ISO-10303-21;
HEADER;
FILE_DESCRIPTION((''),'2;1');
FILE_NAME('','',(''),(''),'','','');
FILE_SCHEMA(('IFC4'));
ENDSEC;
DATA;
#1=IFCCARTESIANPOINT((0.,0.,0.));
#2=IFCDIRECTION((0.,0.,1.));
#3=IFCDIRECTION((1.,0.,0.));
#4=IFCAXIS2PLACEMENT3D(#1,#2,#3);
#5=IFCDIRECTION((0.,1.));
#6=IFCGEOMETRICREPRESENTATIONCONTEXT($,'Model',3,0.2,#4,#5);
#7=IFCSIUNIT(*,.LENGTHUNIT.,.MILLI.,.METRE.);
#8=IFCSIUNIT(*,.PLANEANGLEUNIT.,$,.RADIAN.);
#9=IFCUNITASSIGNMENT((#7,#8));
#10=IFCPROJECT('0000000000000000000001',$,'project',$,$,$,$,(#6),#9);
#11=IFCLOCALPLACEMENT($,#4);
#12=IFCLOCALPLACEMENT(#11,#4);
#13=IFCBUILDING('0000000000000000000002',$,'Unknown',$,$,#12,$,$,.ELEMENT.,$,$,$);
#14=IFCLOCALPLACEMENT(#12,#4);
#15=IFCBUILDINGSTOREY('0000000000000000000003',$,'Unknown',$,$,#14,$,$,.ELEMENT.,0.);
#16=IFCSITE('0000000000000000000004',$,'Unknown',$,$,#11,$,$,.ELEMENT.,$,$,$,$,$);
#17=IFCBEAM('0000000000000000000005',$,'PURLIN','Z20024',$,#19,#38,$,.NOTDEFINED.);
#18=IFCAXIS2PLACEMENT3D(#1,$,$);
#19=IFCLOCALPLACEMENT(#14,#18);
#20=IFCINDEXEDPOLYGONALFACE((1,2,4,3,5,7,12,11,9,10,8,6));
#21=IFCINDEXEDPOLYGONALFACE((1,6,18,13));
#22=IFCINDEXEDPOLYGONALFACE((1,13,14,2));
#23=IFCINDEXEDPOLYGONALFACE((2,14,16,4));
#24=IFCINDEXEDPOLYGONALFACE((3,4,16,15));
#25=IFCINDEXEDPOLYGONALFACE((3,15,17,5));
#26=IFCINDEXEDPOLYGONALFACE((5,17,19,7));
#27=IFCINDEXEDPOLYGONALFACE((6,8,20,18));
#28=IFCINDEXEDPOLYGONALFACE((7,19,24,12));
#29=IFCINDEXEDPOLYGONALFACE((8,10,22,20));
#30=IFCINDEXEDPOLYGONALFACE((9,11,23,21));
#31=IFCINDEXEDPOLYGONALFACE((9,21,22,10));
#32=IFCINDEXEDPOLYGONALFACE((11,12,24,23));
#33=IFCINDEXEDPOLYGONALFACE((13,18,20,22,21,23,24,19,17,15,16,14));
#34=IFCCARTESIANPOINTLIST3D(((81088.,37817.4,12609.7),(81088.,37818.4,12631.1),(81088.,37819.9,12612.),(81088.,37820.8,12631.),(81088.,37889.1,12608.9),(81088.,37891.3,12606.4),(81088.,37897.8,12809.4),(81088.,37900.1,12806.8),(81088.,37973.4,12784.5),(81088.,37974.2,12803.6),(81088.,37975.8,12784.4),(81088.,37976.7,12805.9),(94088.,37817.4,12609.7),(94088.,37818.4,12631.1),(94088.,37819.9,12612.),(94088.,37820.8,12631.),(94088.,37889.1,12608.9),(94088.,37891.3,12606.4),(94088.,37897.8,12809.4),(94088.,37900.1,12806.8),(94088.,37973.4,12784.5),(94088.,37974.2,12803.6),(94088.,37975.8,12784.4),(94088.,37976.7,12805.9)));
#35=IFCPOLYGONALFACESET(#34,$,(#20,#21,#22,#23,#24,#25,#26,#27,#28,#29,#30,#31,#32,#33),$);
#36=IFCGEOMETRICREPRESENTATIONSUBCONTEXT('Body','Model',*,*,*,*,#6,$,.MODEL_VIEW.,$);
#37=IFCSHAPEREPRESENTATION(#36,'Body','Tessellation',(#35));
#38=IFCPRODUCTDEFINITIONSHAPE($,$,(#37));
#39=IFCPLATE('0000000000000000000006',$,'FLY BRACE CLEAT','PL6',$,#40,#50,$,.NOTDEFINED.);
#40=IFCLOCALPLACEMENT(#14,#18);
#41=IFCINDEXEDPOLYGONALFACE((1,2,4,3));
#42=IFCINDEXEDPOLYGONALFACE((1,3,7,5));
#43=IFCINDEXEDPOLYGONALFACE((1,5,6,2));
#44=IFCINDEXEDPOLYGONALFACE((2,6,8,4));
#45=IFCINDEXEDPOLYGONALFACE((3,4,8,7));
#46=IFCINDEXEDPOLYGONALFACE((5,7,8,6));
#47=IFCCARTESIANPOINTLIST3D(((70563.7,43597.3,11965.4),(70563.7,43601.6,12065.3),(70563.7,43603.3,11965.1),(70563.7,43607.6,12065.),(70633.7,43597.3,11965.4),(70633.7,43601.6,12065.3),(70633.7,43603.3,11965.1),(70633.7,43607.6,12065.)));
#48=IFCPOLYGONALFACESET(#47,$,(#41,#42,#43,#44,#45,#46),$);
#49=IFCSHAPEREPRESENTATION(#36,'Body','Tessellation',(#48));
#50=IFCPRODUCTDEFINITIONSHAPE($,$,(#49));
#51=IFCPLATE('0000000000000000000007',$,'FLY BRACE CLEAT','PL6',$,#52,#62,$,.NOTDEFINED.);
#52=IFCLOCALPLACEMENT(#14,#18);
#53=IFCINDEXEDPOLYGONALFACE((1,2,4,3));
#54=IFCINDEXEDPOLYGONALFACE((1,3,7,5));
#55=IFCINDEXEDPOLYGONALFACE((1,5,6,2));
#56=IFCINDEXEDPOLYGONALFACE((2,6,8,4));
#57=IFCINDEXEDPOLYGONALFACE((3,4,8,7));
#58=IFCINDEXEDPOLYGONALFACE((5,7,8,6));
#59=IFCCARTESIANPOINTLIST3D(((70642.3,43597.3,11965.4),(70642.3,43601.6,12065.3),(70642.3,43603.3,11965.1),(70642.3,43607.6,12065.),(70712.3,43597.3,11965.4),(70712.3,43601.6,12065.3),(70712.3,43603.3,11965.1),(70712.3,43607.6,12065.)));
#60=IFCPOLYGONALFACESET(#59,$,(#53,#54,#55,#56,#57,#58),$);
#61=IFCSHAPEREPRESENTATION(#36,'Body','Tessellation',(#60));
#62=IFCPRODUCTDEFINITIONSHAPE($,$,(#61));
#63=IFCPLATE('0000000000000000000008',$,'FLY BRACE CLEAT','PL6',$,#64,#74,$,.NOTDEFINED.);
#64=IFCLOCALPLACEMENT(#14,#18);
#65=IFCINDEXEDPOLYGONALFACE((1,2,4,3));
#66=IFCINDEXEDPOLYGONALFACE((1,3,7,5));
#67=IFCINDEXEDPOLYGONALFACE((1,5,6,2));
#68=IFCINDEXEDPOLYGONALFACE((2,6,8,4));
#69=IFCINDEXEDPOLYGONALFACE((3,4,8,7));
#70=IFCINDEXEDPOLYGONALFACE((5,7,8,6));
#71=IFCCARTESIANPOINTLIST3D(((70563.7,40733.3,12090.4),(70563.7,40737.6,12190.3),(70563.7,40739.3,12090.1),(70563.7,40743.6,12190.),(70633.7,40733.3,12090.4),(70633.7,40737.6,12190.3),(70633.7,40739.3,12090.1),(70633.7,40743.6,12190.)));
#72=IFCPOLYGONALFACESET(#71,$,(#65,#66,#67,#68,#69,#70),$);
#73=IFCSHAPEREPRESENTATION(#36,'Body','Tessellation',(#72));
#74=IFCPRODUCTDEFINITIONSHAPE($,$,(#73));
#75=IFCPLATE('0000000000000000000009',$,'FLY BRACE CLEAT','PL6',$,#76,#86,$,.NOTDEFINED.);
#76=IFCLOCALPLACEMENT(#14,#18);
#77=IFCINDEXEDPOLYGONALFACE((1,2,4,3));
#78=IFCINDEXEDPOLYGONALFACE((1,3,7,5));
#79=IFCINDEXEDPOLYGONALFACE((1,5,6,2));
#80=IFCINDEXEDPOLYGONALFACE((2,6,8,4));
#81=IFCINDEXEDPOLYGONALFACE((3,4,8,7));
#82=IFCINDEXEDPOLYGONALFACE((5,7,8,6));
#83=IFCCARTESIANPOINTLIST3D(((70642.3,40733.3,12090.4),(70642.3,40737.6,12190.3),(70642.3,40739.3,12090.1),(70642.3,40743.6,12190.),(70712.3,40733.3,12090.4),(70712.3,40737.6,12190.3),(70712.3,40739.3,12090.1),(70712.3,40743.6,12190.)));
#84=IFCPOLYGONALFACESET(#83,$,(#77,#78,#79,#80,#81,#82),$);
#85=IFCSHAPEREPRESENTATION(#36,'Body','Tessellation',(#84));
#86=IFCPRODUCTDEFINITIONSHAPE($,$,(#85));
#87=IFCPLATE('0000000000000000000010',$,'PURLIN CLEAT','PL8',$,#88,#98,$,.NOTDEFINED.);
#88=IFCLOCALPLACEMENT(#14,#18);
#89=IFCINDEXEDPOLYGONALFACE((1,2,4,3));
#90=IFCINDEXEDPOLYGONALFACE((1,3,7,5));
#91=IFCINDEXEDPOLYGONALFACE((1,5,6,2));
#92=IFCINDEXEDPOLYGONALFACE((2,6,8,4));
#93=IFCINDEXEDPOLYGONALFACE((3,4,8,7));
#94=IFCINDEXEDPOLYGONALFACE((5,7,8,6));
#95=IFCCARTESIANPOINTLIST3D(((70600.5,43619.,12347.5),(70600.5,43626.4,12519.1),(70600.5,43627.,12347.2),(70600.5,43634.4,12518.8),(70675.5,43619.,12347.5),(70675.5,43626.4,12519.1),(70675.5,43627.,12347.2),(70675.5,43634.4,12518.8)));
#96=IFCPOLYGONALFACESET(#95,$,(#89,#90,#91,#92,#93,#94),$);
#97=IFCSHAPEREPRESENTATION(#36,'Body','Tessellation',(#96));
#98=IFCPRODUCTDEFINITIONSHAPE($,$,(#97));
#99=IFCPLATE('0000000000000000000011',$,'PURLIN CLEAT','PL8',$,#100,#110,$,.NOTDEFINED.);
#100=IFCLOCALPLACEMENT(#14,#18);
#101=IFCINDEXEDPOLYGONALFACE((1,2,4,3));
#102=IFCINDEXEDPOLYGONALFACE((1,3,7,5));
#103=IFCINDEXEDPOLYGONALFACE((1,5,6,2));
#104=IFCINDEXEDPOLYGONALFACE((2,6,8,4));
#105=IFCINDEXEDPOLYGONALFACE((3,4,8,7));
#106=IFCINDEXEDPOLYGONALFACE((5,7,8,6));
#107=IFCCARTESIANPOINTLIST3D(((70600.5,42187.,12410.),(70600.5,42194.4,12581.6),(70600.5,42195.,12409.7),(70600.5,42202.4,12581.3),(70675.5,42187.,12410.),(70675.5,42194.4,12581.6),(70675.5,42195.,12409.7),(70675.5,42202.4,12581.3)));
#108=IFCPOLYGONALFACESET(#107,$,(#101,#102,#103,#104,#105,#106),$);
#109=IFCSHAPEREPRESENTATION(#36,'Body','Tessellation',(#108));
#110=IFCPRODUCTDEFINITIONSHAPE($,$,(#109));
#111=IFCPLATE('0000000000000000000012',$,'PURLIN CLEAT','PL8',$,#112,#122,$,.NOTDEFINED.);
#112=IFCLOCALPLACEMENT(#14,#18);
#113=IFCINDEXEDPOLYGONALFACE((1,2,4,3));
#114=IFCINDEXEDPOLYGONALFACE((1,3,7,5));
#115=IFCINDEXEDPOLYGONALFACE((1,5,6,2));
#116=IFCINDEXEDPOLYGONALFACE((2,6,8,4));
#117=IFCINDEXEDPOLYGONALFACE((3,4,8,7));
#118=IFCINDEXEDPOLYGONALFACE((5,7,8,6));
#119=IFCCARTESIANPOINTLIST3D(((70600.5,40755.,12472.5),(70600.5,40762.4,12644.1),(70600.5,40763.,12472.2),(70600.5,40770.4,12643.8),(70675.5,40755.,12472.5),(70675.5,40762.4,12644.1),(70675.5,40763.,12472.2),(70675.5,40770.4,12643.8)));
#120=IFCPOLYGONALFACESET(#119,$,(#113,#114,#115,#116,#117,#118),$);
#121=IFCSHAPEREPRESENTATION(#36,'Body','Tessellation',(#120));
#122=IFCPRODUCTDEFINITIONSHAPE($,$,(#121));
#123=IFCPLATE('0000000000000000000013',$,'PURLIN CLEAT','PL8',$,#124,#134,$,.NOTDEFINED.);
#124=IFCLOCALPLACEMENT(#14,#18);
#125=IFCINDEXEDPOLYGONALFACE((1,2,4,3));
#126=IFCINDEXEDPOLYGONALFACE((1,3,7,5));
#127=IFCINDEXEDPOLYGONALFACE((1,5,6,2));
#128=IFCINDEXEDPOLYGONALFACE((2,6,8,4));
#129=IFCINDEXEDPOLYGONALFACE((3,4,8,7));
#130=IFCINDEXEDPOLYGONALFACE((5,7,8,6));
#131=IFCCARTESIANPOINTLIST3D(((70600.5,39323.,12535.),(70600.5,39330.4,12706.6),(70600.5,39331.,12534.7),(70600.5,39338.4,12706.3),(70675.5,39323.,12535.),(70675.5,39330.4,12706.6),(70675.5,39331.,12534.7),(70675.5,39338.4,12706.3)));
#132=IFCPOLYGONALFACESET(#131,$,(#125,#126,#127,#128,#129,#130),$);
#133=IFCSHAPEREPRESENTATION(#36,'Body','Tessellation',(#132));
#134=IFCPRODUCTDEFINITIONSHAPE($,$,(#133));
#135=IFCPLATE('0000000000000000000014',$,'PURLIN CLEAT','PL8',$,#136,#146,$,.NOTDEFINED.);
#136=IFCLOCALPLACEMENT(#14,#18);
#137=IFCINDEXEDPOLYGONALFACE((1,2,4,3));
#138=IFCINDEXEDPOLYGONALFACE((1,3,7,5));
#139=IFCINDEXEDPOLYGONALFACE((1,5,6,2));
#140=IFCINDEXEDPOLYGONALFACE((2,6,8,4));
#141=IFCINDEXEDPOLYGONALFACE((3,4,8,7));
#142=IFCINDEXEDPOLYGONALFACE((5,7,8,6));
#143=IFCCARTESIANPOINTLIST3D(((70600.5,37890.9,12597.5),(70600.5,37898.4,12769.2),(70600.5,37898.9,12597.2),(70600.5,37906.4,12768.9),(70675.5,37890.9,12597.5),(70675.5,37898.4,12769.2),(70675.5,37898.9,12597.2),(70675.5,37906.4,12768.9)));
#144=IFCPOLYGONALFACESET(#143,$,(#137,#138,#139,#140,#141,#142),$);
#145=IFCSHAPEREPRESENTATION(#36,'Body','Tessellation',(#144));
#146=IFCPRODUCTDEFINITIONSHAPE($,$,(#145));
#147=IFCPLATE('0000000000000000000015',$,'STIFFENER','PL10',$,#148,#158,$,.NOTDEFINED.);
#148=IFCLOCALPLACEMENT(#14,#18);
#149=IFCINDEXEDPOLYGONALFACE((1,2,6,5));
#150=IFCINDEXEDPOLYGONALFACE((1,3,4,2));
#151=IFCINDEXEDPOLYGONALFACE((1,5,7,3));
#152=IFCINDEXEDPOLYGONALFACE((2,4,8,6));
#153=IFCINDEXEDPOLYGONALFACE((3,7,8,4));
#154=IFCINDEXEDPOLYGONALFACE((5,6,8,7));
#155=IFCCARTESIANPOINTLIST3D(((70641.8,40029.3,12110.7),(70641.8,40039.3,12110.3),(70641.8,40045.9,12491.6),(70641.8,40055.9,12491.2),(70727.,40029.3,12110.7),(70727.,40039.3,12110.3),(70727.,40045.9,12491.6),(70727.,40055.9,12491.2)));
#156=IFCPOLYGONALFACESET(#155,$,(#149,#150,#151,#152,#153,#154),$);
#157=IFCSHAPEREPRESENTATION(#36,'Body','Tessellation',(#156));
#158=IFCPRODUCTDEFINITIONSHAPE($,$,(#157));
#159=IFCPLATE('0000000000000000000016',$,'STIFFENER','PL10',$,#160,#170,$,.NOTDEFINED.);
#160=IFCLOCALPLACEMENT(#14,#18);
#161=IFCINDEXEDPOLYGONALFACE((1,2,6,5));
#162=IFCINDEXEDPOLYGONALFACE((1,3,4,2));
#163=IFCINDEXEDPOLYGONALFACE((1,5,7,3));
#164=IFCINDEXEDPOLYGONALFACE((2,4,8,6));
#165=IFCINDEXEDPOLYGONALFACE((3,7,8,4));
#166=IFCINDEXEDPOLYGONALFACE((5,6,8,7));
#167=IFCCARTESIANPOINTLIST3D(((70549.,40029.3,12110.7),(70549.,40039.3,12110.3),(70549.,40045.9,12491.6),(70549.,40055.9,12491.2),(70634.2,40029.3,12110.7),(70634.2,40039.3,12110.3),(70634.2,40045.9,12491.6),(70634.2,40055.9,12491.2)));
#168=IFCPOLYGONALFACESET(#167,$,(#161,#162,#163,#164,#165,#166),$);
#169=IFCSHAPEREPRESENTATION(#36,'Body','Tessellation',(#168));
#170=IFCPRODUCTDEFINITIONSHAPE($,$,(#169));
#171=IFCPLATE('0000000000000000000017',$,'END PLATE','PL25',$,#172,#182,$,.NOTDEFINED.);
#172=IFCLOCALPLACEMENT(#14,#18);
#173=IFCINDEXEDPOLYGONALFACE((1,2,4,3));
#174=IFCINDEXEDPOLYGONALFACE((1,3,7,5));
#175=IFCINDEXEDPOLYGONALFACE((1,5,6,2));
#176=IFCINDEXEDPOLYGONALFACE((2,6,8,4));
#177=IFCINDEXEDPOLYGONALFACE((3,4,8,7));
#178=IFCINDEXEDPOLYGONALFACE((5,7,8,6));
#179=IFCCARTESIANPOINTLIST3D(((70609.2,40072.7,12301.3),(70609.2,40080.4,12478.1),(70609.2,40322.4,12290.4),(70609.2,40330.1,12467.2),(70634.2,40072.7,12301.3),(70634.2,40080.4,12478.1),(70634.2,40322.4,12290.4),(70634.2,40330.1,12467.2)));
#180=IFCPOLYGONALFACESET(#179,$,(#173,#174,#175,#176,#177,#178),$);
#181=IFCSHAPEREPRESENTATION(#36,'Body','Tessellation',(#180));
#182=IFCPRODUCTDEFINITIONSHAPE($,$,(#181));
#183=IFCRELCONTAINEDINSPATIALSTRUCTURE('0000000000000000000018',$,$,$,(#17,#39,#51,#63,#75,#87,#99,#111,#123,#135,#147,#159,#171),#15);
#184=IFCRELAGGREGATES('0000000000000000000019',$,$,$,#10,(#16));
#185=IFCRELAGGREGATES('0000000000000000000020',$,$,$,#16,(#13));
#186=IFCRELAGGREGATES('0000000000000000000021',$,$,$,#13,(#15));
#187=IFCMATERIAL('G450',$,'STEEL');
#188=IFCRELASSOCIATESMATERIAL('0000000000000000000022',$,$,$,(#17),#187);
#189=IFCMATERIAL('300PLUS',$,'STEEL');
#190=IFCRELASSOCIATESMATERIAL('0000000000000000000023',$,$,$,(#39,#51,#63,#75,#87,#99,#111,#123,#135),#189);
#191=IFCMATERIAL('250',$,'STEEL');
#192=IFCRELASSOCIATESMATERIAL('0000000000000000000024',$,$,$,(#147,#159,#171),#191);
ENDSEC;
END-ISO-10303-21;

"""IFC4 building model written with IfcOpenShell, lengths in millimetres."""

from ifc_helpers import new_model, si_unit, direction, frame, origin_with_axes, place, context, subcontext, project, spatial, line, indexed_curve, outline, extrude, material, element, save


model = new_model("IFC4")

# Units and contexts
model_context = context("Model", 3, precision=0.2, world=origin_with_axes(), true_north=direction((0.0, 1.0)))
body_context = subcontext(model_context, "Body", "Model", "MODEL_VIEW")
ifc_project = project(units=[si_unit("LENGTHUNIT", "METRE", prefix="MILLI"), si_unit("PLANEANGLEUNIT", "RADIAN")], contexts=[model_context])

# Site, building, storey
site_placement = place(None, origin_with_axes())
site = spatial("IfcSite", under=ifc_project, at=site_placement, Name="Unknown", CompositionType="ELEMENT")
building_placement = place(site_placement, origin_with_axes())
building = spatial("IfcBuilding", under=site, at=building_placement, Name="Unknown", CompositionType="ELEMENT")
storey_placement = place(building_placement, origin_with_axes())
storey = spatial("IfcBuildingStorey", under=building, at=storey_placement, Name="Unknown", CompositionType="ELEMENT", Elevation=0.0)

# Shared definitions
ifc_material_1 = material(Name="300PLUS", Category="STEEL")

# Beam
ifc_material_2 = material(Name="G450", Category="STEEL")
for number, where, z_axis, x_axis, name in (
    (1, (81088.0, 37894.6, 12707.9), (0.0, -0.999048, 0.043619), (1.0, 0.0, 0.0), "PURLIN"),
):
    element("IfcBeam", number, at=place(storey_placement, frame(where, z_axis=z_axis, x_axis=x_axis)), inside=storey, material=ifc_material_2, Name=name, Description="Z20024", PredefinedType="NOTDEFINED", context=body_context, shape_type="SolidModel", body=[
        extrude(outline(indexed_curve([(72.8, -101.5), (72.8, -80.0), (70.4, -80.0), (70.4, -99.1), (1.2, -99.1), (1.2, 101.5), (-77.8, 101.5), (-77.8, 80.0), (-75.4, 80.0), (-75.4, 99.1), (-1.2, 99.1), (-1.2, -101.5)], segments=[line(1, 2, 3, 4, 5, 6, 7, 8, 9, 10, 11, 12, 1)])), frame((0.0, 0.0, 0.0), z_axis=(-1.0, 0.0, 0.0), x_axis=(0.0, 0.0, 1.0)), (0.0, 0.0, -1.0), 13000.0),
    ])

# Plates
for number, where, z_axis, x_axis, name in (
    (2, (70633.7, 43604.6, 12065.1), (0.0, -0.999075, 0.043003), (-1.0, 0.0, 0.0), "FLY BRACE CLEAT"),
    (3, (70712.3, 43604.6, 12065.1), (0.0, -0.999075, 0.043003), (-1.0, 0.0, 0.0), "FLY BRACE CLEAT"),
    (4, (70633.7, 40740.6, 12190.1), (0.0, -0.999075, 0.043003), (-1.0, 0.0, 0.0), "FLY BRACE CLEAT"),
    (5, (70712.3, 40740.6, 12190.1), (0.0, -0.999075, 0.043003), (-1.0, 0.0, 0.0), "FLY BRACE CLEAT"),
):
    element("IfcPlate", number, at=place(storey_placement, frame(where, z_axis=z_axis, x_axis=x_axis)), inside=storey, material=ifc_material_1, Name=name, Description="PL6", PredefinedType="NOTDEFINED", context=body_context, shape_type="SolidModel", body=[
        extrude(outline(indexed_curve([(0.0, 0.0), (70.0, 0.0), (70.0, 100.0), (0.0, 100.0)], segments=[line(1, 2, 3, 4, 1)])), frame((0.0, 0.0, 3.0), z_axis=(0.0, 0.0, 1.0), x_axis=(1.0, 0.0, 0.0)), (0.0, 0.0, -1.0), 6.0),
    ])
for number, where, z_axis, x_axis, name in (
    (6, (70600.5, 43623.0, 12347.4), (0.0, -0.999071, 0.043084), (1.0, 0.0, 0.0), "PURLIN CLEAT"),
    (7, (70600.5, 42191.0, 12409.9), (0.0, -0.999071, 0.043084), (1.0, 0.0, 0.0), "PURLIN CLEAT"),
    (8, (70600.5, 40759.0, 12472.4), (0.0, -0.999071, 0.043084), (1.0, 0.0, 0.0), "PURLIN CLEAT"),
    (9, (70600.5, 39327.0, 12534.9), (0.0, -0.999071, 0.043084), (1.0, 0.0, 0.0), "PURLIN CLEAT"),
):
    element("IfcPlate", number, at=place(storey_placement, frame(where, z_axis=z_axis, x_axis=x_axis)), inside=storey, material=ifc_material_1, Name=name, Description="PL8", PredefinedType="NOTDEFINED", context=body_context, shape_type="SolidModel", body=[
        extrude(outline(indexed_curve([(0.0, 0.0), (75.0, 0.0), (75.0, 171.8), (0.0, 171.8)], segments=[line(1, 2, 3, 4, 1)])), frame((0.0, 0.0, 4.0), z_axis=(0.0, 0.0, 1.0), x_axis=(1.0, 0.0, 0.0)), (0.0, 0.0, -1.0), 8.0),
    ])
plate_1_placement = place(storey_placement, frame((70600.5, 37894.9, 12597.4), z_axis=(0.0, -0.999047, 0.043639), x_axis=(1.0, 0.0, 0.0)))
element("IfcPlate", 10, at=plate_1_placement, inside=storey, material=ifc_material_1, Name="PURLIN CLEAT", Description="PL8", PredefinedType="NOTDEFINED", context=body_context, shape_type="SolidModel", body=[
    extrude(outline(indexed_curve([(0.0, 0.0), (75.0, 0.0), (75.0, 171.9), (0.0, 171.9)], segments=[line(1, 2, 3, 4, 1)])), frame((0.0, 0.0, 4.0), z_axis=(0.0, 0.0, 1.0), x_axis=(1.0, 0.0, 0.0)), (0.0, 0.0, -1.0), 8.0),
])
ifc_material_3 = material(Name="250", Category="STEEL")
for number, where, z_axis, x_axis, name in (
    (11, (70727.0, 40050.9, 12491.4), (0.0, -0.999052, 0.04354), (-1.0, 0.0, 0.0), "STIFFENER"),
    (12, (70634.2, 40050.9, 12491.4), (0.0, -0.999052, 0.04354), (-1.0, 0.0, 0.0), "STIFFENER"),
):
    element("IfcPlate", number, at=place(storey_placement, frame(where, z_axis=z_axis, x_axis=x_axis)), inside=storey, material=ifc_material_3, Name=name, Description="PL10", PredefinedType="NOTDEFINED", context=body_context, shape_type="SolidModel", body=[
        extrude(outline(indexed_curve([(0.0, 0.0), (85.2, 0.0), (85.2, 381.3), (0.0, 381.3)], segments=[line(1, 2, 3, 4, 1)])), frame((0.0, 0.0, 5.0), z_axis=(0.0, 0.0, 1.0), x_axis=(1.0, 0.0, 0.0)), (0.0, 0.0, -1.0), 10.0),
    ])
plate_2_placement = place(storey_placement, frame((70621.7, 40322.4, 12290.4), z_axis=(-1.0, 0.0, 0.0), x_axis=(0.0, -0.999049, 0.043611)))
element("IfcPlate", 13, at=plate_2_placement, inside=storey, material=ifc_material_3, Name="END PLATE", Description="PL25", PredefinedType="NOTDEFINED", context=body_context, shape_type="SolidModel", body=[
    extrude(outline(indexed_curve([(0.0, 0.0), (249.9, 0.0), (250.0, 177.0), (0.0, 177.0)], segments=[line(1, 2, 3, 4, 1)])), frame((0.0, 0.0, 12.5), z_axis=(0.0, 0.0, 1.0), x_axis=(1.0, 0.0, 0.0)), (0.0, 0.0, -1.0), 25.0),
])

save(model, "model.ifc")
